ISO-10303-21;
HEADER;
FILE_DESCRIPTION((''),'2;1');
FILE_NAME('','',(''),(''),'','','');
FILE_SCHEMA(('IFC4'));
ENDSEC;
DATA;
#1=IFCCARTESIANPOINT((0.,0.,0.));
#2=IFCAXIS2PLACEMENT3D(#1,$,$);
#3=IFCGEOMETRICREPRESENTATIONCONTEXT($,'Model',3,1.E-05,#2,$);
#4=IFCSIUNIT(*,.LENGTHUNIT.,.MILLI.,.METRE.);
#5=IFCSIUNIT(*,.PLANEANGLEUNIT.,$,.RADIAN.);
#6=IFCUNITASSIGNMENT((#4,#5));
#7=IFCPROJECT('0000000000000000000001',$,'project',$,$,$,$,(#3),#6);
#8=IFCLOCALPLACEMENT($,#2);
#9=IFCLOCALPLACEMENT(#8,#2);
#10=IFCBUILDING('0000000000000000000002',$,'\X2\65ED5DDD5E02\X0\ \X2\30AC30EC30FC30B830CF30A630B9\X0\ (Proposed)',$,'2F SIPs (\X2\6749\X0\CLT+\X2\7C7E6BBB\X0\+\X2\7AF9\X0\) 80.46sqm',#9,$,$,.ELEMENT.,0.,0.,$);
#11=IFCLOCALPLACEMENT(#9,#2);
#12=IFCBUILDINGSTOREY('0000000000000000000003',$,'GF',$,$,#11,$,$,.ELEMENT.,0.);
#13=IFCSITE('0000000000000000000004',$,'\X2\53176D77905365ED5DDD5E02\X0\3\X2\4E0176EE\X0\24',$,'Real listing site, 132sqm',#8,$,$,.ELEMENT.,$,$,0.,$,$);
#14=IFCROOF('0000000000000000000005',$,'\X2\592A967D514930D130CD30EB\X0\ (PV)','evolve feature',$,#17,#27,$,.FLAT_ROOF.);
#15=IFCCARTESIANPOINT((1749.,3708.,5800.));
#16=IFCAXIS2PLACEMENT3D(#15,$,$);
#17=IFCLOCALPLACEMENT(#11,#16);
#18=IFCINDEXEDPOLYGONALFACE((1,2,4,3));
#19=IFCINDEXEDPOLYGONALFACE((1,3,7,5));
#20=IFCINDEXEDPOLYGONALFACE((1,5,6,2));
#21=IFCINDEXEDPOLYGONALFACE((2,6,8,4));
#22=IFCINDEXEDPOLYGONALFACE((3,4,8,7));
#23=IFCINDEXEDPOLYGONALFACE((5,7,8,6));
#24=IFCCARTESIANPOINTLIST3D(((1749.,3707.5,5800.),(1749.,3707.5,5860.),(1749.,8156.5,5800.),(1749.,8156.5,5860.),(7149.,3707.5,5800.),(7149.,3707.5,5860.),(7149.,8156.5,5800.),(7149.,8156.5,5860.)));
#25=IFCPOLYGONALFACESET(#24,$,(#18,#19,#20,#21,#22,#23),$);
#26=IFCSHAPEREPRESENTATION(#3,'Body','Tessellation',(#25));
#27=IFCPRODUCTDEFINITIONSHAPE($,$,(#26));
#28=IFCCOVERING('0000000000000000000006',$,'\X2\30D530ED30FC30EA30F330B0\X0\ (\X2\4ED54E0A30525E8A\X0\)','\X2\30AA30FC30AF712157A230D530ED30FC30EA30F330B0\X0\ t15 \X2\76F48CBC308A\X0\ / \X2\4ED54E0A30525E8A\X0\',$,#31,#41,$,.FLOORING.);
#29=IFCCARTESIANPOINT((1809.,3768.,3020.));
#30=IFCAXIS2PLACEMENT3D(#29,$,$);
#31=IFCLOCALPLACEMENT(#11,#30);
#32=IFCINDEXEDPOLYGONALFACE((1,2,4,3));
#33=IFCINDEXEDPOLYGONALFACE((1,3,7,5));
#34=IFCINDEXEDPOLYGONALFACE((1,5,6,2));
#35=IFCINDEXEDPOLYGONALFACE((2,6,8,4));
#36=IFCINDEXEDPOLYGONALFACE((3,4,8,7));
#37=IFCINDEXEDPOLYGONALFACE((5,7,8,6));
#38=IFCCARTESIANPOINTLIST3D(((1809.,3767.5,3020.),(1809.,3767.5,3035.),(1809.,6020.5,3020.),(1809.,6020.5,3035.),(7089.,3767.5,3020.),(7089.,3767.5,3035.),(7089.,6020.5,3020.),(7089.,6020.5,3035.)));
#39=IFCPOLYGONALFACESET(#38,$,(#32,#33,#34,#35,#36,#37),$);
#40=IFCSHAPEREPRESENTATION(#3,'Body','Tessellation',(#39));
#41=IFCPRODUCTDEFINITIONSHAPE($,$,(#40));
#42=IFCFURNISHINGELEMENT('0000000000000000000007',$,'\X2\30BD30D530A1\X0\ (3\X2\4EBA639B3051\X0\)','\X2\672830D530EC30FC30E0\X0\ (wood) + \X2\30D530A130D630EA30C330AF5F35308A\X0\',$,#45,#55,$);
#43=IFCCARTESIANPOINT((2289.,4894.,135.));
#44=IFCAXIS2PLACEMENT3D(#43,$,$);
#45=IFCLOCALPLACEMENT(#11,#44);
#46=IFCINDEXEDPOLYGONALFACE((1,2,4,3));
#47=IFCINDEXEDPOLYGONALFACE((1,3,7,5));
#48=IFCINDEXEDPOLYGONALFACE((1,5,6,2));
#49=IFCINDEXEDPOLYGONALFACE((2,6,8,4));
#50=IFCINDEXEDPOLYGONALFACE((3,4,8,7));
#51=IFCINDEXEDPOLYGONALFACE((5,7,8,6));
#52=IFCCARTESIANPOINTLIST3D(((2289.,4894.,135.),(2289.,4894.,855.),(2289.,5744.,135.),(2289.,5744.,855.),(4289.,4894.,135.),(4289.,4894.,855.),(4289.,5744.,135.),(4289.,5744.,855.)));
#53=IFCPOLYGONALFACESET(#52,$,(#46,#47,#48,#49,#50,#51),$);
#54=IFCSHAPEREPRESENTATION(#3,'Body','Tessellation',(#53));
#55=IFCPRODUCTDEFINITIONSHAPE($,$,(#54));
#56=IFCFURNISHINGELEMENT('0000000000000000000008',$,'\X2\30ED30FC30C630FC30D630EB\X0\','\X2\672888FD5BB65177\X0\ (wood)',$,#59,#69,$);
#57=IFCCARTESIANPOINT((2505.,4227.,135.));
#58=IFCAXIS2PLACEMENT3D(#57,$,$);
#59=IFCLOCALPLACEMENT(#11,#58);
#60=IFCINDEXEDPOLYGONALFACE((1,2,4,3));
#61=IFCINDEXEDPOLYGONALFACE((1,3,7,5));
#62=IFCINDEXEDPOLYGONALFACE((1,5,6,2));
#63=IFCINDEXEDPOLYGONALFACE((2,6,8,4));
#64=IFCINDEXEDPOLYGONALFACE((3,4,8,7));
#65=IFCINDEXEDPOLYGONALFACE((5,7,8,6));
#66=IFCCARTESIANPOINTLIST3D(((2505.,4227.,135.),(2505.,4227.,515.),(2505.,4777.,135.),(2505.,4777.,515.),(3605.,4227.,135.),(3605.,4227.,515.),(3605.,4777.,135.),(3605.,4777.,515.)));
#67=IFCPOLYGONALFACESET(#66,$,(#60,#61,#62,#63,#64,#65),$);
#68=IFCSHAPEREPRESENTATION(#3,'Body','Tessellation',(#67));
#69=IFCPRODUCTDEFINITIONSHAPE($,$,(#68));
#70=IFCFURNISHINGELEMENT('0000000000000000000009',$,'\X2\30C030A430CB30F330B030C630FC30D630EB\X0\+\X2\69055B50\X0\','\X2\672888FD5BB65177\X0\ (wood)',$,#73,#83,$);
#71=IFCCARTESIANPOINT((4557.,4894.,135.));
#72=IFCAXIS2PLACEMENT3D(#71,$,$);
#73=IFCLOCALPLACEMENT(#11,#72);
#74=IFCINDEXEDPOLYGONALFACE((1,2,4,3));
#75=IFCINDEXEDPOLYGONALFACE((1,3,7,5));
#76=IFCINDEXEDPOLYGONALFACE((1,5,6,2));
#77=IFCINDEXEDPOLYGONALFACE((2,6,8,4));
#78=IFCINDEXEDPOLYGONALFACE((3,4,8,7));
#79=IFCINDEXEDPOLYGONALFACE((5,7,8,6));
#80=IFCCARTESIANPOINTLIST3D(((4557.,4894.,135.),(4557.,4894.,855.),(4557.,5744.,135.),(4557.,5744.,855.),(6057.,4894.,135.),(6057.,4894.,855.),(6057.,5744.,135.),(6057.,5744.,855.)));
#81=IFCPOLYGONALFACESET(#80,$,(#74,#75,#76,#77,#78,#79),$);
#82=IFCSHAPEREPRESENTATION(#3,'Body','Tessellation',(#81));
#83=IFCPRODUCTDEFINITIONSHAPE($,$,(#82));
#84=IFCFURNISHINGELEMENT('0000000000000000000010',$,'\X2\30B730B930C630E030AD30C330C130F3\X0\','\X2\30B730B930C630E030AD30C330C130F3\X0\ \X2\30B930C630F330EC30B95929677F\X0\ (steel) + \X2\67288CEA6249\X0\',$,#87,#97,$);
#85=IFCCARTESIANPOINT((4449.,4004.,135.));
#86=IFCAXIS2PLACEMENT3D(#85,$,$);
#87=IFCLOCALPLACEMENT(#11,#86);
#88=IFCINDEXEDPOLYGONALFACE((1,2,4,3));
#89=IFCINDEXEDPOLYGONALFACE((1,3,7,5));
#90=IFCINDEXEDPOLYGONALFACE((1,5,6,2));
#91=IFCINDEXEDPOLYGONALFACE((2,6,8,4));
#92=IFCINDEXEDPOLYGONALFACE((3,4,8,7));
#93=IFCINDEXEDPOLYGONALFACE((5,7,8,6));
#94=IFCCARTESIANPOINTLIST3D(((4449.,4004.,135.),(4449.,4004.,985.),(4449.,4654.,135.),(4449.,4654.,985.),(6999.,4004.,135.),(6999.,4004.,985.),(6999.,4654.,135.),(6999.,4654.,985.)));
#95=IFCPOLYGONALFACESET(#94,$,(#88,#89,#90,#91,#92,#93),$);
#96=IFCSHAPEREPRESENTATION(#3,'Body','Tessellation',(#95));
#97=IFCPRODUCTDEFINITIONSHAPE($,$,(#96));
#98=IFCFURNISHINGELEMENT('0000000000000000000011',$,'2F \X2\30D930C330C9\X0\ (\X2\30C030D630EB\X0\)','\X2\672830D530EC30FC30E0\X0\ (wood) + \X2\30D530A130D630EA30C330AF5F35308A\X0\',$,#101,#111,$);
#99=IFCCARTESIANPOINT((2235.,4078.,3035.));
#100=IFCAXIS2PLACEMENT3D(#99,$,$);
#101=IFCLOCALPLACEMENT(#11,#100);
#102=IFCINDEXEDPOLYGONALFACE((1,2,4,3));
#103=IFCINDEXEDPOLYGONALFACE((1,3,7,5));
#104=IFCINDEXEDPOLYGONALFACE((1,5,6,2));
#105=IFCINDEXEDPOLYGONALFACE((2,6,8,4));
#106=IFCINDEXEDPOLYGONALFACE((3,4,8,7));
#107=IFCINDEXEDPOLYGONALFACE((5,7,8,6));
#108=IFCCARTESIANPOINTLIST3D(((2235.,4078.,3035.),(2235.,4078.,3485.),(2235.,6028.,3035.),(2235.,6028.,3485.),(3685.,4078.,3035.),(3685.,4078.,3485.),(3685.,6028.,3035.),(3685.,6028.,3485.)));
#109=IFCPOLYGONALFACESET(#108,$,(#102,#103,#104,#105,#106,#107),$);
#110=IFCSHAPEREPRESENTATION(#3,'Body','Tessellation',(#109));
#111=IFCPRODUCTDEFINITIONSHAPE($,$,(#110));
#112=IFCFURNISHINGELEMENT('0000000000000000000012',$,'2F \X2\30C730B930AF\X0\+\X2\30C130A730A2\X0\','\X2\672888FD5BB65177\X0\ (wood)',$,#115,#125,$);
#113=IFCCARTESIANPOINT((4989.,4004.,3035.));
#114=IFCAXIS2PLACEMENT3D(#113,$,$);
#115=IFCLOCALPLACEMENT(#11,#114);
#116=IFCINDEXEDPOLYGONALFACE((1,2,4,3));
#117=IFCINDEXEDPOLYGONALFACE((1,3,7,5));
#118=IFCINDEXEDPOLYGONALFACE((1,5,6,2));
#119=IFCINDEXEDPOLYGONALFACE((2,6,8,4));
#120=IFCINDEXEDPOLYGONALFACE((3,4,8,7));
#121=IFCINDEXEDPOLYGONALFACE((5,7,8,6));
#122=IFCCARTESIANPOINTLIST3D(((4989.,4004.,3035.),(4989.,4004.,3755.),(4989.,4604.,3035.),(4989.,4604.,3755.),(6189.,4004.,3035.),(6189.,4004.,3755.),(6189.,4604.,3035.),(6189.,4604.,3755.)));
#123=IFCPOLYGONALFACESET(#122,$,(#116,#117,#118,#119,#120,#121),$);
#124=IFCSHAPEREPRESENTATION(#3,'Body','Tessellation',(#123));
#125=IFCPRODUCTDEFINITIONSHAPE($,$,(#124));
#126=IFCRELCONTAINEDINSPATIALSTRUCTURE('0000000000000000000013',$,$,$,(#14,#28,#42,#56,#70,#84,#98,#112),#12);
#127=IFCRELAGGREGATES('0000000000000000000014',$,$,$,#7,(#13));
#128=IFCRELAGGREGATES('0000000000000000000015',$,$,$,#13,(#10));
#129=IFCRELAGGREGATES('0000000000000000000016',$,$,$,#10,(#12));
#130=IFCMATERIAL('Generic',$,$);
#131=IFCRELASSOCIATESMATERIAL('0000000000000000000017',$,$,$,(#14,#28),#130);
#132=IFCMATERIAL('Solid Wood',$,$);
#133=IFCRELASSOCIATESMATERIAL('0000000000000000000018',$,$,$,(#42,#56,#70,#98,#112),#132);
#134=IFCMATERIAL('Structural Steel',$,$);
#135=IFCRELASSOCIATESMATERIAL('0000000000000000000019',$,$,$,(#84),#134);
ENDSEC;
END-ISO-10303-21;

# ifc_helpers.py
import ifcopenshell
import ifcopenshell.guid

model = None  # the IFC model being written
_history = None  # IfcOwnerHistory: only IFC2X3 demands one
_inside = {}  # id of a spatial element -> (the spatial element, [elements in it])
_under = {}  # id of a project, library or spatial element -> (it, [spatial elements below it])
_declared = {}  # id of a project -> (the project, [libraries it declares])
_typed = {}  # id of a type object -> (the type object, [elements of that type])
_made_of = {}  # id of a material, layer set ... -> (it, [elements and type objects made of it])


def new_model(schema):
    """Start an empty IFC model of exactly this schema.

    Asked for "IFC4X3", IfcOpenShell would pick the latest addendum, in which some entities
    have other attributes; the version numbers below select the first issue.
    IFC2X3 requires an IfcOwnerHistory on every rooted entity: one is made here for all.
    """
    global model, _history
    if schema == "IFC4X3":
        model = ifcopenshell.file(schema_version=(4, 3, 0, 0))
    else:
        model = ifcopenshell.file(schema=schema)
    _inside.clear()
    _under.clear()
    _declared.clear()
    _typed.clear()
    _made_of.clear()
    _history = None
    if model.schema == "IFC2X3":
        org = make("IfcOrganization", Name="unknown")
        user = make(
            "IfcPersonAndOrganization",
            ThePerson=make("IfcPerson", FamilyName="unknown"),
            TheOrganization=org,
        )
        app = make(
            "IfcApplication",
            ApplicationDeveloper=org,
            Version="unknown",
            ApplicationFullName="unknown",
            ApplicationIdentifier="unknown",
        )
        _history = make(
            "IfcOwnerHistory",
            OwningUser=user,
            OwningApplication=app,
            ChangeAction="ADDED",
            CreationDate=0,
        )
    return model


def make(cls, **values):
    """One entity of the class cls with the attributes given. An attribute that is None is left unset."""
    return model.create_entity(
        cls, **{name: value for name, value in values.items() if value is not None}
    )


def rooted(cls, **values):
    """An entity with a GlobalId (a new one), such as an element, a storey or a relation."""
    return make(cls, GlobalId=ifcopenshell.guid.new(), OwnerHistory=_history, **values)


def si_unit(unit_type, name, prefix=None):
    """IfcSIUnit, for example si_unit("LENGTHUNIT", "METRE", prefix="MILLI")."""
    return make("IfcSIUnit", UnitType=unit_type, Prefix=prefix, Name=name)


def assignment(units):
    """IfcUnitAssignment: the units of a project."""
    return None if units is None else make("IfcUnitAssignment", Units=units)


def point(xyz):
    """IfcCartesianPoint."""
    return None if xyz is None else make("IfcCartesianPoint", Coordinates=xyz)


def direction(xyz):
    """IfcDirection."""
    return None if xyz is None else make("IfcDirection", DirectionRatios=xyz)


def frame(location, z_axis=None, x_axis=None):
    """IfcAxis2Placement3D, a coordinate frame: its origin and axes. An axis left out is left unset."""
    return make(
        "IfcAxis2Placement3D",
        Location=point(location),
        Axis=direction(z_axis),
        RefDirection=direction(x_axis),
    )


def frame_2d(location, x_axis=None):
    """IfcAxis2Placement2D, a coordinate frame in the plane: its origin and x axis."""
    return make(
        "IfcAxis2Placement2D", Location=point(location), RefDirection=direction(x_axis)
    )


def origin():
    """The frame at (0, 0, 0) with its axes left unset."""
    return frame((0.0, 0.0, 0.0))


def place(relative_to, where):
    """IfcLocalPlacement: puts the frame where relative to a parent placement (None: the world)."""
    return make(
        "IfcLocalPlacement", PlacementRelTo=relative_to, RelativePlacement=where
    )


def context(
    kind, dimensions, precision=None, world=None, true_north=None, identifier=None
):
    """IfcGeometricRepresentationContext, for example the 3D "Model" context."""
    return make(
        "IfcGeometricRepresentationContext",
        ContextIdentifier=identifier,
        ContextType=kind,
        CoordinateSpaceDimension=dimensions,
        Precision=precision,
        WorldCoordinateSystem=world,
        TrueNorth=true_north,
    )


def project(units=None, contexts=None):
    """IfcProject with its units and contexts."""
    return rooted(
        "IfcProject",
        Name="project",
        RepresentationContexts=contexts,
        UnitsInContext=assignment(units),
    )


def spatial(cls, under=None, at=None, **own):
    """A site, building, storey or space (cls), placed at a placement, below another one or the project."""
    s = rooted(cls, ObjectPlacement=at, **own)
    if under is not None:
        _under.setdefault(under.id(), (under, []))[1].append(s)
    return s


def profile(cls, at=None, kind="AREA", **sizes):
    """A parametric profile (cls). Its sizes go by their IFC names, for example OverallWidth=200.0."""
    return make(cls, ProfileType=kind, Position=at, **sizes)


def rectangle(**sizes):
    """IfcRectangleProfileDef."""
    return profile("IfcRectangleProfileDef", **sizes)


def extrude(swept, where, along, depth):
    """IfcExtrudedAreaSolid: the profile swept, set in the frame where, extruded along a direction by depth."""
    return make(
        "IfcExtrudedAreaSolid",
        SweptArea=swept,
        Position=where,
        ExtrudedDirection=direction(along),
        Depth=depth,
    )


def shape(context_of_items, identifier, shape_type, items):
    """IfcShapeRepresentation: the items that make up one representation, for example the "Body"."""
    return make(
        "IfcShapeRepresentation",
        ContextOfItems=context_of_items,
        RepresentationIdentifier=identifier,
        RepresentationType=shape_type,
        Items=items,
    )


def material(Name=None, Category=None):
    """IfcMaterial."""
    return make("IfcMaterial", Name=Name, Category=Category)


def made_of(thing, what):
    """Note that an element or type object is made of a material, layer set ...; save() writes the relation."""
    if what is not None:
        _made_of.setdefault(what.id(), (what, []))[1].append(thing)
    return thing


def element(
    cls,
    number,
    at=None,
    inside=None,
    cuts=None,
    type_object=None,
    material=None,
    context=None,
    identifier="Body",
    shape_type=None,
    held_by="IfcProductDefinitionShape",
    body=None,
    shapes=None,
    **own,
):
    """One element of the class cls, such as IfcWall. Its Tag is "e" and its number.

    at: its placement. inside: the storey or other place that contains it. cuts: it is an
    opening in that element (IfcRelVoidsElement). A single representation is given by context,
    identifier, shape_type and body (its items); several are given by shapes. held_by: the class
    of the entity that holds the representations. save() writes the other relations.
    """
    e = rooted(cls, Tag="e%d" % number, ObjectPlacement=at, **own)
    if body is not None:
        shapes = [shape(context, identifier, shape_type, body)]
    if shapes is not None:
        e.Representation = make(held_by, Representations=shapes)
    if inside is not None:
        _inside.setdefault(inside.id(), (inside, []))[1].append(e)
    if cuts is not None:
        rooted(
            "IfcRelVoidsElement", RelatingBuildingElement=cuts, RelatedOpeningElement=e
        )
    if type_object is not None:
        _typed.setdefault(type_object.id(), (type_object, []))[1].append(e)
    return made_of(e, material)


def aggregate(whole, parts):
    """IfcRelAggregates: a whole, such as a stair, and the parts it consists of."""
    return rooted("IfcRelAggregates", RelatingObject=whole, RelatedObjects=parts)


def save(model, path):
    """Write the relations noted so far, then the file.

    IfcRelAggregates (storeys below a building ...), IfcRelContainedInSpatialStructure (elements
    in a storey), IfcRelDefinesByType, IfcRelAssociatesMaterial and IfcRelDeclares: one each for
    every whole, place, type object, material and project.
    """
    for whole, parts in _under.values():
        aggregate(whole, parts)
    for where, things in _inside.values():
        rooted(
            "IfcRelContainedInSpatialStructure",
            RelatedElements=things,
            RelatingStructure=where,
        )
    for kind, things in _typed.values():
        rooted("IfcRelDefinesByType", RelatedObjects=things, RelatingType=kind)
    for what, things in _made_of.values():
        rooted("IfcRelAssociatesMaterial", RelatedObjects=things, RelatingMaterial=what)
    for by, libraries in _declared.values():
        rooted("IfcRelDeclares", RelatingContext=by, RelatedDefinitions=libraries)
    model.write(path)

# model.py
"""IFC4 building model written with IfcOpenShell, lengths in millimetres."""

from ifc_helpers import new_model, si_unit, frame, frame_2d, origin, place, context, project, spatial, rectangle, extrude, material, element, save


model = new_model("IFC4")

# Units and contexts
model_context = context("Model", 3, precision=1e-05, world=origin())
ifc_project = project(units=[si_unit("LENGTHUNIT", "METRE", prefix="MILLI"), si_unit("PLANEANGLEUNIT", "RADIAN")], contexts=[model_context])

# Site, building, storey
site_placement = place(None, origin())
site = spatial("IfcSite", under=ifc_project, at=site_placement, Name="北海道旭川市3丁目24", ObjectType="Real listing site, 132sqm", CompositionType="ELEMENT", RefElevation=0.0)
building_placement = place(site_placement, origin())
building = spatial("IfcBuilding", under=site, at=building_placement, Name="旭川市 ガレージハウス (Proposed)", ObjectType="2F SIPs (杉CLT+籾殻+竹) 80.46sqm", CompositionType="ELEMENT", ElevationOfRefHeight=0.0, ElevationOfTerrain=0.0)
storey_placement = place(building_placement, origin())
storey = spatial("IfcBuildingStorey", under=building, at=storey_placement, Name="GF", CompositionType="ELEMENT", Elevation=0.0)

# Shared definitions
ifc_material_1 = material(Name="Solid Wood")

# Shared definitions
ifc_material_2 = material(Name="Generic")

# Roof
ifc_material_3 = material(Name="Structural Steel")
roof_1_placement = place(storey_placement, frame((1749.0, 3708.0, 5800.0)))
element("IfcRoof", 1, at=roof_1_placement, inside=storey, material=ifc_material_2, Name="太陽光パネル (PV)", Description="evolve feature", PredefinedType="FLAT_ROOF", context=model_context, shape_type="SweptSolid", body=[
    extrude(rectangle(XDim=5400.0, YDim=4449.0, at=frame_2d((2700.0, 2224.0))), frame((1749.0, 3708.0, 5800.0)), (0.0, 0.0, 1.0), 60.0),
])

# Covering
covering_placement = place(storey_placement, frame((1809.0, 3768.0, 3020.0)))
element("IfcCovering", 2, at=covering_placement, inside=storey, material=ifc_material_2, Name="フローリング (仕上げ床)", Description="オーク無垢フローリング t15 直貼り / 仕上げ床", PredefinedType="FLOORING", context=model_context, shape_type="SweptSolid", body=[
    extrude(rectangle(XDim=5280.0, YDim=2253.0, at=frame_2d((2640.0, 1126.0))), frame((1809.0, 3768.0, 3020.0)), (0.0, 0.0, 1.0), 15.0),
])

# Furnishing elements
furnishing_1_placement = place(storey_placement, frame((2289.0, 4894.0, 135.0)))
element("IfcFurnishingElement", 3, at=furnishing_1_placement, inside=storey, material=ifc_material_1, Name="ソファ (3人掛け)", Description="木フレーム (wood) + ファブリック張り", context=model_context, shape_type="SweptSolid", body=[
    extrude(rectangle(XDim=2000.0, YDim=850.0, at=frame_2d((1000.0, 425.0))), frame((2289.0, 4894.0, 135.0)), (0.0, 0.0, 1.0), 720.0),
])
furnishing_2_placement = place(storey_placement, frame((2505.0, 4227.0, 135.0)))
element("IfcFurnishingElement", 4, at=furnishing_2_placement, inside=storey, material=ifc_material_1, Name="ローテーブル", Description="木製家具 (wood)", context=model_context, shape_type="SweptSolid", body=[
    extrude(rectangle(XDim=1100.0, YDim=550.0, at=frame_2d((550.0, 275.0))), frame((2505.0, 4227.0, 135.0)), (0.0, 0.0, 1.0), 380.0),
])
furnishing_3_placement = place(storey_placement, frame((4557.0, 4894.0, 135.0)))
element("IfcFurnishingElement", 5, at=furnishing_3_placement, inside=storey, material=ifc_material_1, Name="ダイニングテーブル+椅子", Description="木製家具 (wood)", context=model_context, shape_type="SweptSolid", body=[
    extrude(rectangle(XDim=1500.0, YDim=850.0, at=frame_2d((750.0, 425.0))), frame((4557.0, 4894.0, 135.0)), (0.0, 0.0, 1.0), 720.0),
])
furnishing_4_placement = place(storey_placement, frame((4449.0, 4004.0, 135.0)))
element("IfcFurnishingElement", 6, at=furnishing_4_placement, inside=storey, material=ifc_material_3, Name="システムキッチン", Description="システムキッチン ステンレス天板 (steel) + 木質扉", context=model_context, shape_type="SweptSolid", body=[
    extrude(rectangle(XDim=2550.0, YDim=650.0, at=frame_2d((1275.0, 325.0))), frame((4449.0, 4004.0, 135.0)), (0.0, 0.0, 1.0), 850.0),
])
furnishing_5_placement = place(storey_placement, frame((2235.0, 4078.0, 3035.0)))
element("IfcFurnishingElement", 7, at=furnishing_5_placement, inside=storey, material=ifc_material_1, Name="2F ベッド (ダブル)", Description="木フレーム (wood) + ファブリック張り", context=model_context, shape_type="SweptSolid", body=[
    extrude(rectangle(XDim=1450.0, YDim=1950.0, at=frame_2d((725.0, 975.0))), frame((2235.0, 4078.0, 3035.0)), (0.0, 0.0, 1.0), 450.0),
])
furnishing_6_placement = place(storey_placement, frame((4989.0, 4004.0, 3035.0)))
element("IfcFurnishingElement", 8, at=furnishing_6_placement, inside=storey, material=ifc_material_1, Name="2F デスク+チェア", Description="木製家具 (wood)", context=model_context, shape_type="SweptSolid", body=[
    extrude(rectangle(XDim=1200.0, YDim=600.0, at=frame_2d((600.0, 300.0))), frame((4989.0, 4004.0, 3035.0)), (0.0, 0.0, 1.0), 720.0),
])

save(model, "model.ifc")
